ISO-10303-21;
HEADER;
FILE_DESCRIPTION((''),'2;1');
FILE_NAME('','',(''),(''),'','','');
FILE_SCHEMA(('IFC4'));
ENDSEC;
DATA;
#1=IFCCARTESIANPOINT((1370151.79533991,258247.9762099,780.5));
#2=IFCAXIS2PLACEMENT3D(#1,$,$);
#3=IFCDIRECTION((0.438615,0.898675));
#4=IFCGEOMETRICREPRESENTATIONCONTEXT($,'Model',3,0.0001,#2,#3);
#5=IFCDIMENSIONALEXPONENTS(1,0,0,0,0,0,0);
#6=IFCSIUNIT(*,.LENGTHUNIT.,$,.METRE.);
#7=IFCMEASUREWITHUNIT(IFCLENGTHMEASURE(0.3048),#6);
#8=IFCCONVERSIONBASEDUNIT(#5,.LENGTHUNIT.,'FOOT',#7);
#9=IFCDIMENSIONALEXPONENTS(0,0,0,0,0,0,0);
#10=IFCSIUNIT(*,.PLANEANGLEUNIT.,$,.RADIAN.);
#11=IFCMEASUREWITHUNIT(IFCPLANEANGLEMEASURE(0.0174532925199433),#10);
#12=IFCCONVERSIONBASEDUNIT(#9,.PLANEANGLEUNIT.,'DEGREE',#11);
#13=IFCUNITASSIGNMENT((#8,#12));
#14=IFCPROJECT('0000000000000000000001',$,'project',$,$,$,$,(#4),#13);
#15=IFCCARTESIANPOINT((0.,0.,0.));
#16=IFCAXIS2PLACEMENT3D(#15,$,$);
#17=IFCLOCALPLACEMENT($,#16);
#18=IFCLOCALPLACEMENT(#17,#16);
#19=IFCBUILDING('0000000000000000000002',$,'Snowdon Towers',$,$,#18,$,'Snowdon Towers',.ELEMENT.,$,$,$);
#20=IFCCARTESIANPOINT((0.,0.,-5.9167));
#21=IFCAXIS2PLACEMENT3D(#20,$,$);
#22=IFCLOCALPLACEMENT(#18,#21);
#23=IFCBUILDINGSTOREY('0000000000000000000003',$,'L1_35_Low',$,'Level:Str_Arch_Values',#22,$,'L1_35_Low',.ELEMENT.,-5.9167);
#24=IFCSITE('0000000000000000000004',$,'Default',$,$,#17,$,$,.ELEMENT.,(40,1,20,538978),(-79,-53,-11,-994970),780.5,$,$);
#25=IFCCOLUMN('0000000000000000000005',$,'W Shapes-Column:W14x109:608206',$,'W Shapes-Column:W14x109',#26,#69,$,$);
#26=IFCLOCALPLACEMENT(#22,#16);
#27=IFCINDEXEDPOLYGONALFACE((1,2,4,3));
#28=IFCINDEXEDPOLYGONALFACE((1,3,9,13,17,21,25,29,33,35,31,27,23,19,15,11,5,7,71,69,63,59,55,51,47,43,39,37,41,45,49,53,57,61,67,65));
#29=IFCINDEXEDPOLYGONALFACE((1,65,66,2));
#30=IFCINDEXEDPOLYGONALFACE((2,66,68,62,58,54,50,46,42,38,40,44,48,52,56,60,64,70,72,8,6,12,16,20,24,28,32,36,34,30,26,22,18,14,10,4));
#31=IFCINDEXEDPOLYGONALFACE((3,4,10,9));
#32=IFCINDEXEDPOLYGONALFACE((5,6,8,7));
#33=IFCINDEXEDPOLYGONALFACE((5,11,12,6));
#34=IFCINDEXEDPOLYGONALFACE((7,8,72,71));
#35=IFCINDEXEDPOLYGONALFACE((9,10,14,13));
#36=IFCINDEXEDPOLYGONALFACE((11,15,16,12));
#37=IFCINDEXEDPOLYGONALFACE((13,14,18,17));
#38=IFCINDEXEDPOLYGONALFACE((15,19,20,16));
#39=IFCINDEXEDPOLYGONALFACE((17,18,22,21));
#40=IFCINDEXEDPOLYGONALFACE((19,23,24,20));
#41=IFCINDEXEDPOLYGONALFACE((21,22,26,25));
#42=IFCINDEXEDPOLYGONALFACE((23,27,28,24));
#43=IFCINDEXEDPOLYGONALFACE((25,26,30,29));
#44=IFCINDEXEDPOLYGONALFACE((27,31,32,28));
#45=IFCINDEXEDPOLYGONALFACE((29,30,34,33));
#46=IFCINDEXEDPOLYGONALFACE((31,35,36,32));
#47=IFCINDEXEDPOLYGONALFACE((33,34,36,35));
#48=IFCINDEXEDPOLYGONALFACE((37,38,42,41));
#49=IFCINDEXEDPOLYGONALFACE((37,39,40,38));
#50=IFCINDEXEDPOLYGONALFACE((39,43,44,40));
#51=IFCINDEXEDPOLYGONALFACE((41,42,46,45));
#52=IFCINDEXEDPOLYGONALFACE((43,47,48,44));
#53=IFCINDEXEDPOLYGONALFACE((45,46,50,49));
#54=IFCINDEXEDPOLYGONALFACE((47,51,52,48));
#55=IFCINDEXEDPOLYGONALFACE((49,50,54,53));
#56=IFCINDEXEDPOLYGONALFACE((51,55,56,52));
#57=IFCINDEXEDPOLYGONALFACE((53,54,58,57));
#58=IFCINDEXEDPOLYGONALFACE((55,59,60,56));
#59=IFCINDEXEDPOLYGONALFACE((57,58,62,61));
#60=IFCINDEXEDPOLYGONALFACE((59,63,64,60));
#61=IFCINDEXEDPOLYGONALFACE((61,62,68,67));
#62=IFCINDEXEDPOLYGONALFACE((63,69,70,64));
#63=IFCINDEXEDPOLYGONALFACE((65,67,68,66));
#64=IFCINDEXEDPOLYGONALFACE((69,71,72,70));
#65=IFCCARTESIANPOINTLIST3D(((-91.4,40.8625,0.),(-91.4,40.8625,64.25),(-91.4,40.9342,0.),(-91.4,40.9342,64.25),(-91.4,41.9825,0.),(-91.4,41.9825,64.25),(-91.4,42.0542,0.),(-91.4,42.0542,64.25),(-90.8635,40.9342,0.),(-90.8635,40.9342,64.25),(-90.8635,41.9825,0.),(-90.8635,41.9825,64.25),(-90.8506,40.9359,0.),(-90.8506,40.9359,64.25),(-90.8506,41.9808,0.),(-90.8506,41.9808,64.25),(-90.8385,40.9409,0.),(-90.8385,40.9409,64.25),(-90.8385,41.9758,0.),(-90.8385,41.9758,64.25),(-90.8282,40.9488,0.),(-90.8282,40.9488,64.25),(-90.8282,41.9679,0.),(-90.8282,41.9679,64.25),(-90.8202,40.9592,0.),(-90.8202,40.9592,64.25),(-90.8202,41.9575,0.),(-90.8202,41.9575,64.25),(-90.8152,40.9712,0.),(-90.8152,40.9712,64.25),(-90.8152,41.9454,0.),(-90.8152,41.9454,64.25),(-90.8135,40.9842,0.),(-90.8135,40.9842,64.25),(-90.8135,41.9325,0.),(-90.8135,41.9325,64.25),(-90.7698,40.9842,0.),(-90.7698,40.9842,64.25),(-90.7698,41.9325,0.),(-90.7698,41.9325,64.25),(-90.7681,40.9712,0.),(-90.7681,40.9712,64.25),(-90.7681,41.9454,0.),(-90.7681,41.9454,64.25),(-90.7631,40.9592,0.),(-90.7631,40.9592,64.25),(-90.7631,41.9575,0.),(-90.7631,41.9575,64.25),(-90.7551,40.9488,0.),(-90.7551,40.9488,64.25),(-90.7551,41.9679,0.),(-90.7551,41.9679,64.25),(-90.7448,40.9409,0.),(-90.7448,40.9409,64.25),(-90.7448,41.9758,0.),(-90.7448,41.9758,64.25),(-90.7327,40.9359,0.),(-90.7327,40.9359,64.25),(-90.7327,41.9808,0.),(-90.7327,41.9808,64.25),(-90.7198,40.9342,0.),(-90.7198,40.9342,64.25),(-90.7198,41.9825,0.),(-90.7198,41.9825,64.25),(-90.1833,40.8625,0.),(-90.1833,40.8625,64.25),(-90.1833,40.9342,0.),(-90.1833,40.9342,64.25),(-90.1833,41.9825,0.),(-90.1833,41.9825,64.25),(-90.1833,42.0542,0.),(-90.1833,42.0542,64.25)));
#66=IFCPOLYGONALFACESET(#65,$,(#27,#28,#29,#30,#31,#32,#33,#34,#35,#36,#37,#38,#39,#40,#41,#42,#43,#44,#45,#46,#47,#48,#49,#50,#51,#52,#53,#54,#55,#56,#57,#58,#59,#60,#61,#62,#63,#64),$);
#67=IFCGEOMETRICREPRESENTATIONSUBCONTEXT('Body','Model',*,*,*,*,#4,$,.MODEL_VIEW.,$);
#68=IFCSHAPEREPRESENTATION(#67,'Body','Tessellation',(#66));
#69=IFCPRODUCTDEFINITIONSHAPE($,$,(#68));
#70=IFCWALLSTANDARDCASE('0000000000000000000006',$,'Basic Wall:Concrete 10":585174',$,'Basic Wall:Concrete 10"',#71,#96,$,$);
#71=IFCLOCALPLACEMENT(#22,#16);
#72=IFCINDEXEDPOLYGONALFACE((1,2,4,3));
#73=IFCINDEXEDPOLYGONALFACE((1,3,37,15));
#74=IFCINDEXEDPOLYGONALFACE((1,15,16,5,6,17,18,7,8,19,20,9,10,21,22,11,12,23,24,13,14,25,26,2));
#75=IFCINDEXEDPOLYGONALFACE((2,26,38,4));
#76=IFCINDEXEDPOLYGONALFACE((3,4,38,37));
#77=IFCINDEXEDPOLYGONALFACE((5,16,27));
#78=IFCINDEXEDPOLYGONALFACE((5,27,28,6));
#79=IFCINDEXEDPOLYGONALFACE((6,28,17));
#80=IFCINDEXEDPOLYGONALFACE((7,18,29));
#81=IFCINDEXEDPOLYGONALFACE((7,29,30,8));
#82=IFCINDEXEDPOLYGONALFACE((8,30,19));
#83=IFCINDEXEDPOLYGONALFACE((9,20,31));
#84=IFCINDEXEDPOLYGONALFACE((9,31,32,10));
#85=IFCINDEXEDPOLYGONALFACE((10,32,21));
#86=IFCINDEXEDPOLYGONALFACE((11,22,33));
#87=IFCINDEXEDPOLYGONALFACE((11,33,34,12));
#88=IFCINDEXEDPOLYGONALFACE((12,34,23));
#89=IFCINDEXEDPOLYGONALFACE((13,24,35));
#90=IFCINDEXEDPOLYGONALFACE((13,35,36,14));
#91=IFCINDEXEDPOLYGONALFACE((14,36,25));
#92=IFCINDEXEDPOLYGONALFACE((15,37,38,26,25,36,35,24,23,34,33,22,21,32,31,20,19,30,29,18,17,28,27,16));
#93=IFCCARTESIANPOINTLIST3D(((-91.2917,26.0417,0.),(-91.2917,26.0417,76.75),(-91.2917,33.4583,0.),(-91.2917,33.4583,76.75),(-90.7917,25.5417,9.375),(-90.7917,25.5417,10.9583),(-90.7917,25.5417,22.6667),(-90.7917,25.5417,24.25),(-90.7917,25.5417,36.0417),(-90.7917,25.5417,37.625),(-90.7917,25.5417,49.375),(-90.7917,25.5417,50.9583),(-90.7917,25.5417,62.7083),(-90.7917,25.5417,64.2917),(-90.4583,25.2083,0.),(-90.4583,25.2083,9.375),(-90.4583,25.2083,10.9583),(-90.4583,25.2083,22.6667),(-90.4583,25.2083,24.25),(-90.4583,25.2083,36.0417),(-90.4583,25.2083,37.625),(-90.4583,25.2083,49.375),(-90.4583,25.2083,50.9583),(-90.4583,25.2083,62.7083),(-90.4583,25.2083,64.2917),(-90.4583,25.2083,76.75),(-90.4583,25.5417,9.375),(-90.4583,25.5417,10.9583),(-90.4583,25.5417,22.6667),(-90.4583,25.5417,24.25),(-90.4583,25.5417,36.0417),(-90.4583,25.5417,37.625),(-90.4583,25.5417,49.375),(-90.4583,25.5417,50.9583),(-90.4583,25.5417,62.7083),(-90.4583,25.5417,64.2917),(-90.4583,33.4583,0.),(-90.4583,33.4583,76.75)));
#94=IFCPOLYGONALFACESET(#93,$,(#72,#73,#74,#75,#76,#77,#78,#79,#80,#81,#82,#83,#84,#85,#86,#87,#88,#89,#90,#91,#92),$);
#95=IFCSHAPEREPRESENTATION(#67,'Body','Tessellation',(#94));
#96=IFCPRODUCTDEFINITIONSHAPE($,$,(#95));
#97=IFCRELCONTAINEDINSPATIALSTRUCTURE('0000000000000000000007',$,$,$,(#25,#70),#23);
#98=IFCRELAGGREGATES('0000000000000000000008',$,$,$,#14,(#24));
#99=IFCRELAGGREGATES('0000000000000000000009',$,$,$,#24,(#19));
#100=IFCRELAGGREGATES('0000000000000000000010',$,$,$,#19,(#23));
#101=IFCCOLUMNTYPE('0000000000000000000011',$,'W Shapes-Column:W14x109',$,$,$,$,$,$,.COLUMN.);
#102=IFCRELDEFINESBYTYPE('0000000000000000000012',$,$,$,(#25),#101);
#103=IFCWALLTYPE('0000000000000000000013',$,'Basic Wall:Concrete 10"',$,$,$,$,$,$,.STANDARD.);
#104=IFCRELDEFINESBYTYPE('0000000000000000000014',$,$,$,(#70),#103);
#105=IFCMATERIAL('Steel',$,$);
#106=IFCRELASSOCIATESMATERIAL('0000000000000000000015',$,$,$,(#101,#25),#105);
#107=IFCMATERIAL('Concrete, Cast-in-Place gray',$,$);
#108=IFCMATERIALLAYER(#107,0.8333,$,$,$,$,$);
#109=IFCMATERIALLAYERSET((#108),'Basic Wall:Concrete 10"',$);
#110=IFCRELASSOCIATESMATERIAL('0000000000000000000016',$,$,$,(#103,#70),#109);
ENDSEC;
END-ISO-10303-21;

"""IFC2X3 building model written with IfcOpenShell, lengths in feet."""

from ifc_helpers import new_model, entity, si_unit, converted_unit, direction, frame, frame_2d, origin, place, context, subcontext, project, spatial, polyline, rectangle, i_section, outline, extrude, source, transform, mapped, material, layer, layer_set, layer_usage, type_object, type_shapes, element, save


model = new_model("IFC2X3")

# Units and contexts
model_context = context("Model", 3, precision=0.0001, world=frame((1370151.79533991, 258247.9762099, 780.5)), true_north=direction((0.438615, 0.898675)))
body_context = subcontext(model_context, "Body", "Model", "MODEL_VIEW")
ifc_project = project(units=[converted_unit("LENGTHUNIT", "FOOT", entity("IfcLengthMeasure", 0.3048), si_unit("LENGTHUNIT", "METRE"), dimensions=[1, 0, 0, 0, 0, 0, 0]), converted_unit("PLANEANGLEUNIT", "DEGREE", entity("IfcPlaneAngleMeasure", 0.0174532925199433), si_unit("PLANEANGLEUNIT", "RADIAN"), dimensions=[0, 0, 0, 0, 0, 0, 0])], contexts=[model_context])

# Site, building, storey
site_placement = place(None, origin())
site = spatial("IfcSite", under=ifc_project, at=site_placement, Name="Default", CompositionType="ELEMENT", RefLatitude=(40, 1, 20, 538978), RefLongitude=(-79, -53, -11, -994970), RefElevation=780.5)
building_placement = place(site_placement, origin())
building = spatial("IfcBuilding", under=site, at=building_placement, Name="Snowdon Towers", LongName="Snowdon Towers", CompositionType="ELEMENT")
storey_placement = place(building_placement, frame((0.0, 0.0, -5.9167)))
storey = spatial("IfcBuildingStorey", under=building, at=storey_placement, Name="L1_35_Low", ObjectType="Level:Str_Arch_Values", LongName="L1_35_Low", CompositionType="ELEMENT", Elevation=-5.9167)

# Column
ifc_material_1 = material(Name="Steel")
column_type = type_object("IfcColumnType", Name="W Shapes-Column:W14x109", PredefinedType="COLUMN", material=ifc_material_1)
shared_shape = source(origin(), body_context, "Body", "SweptSolid", [
    extrude(i_section(OverallWidth=1.2167, OverallDepth=1.1917, WebThickness=0.0438, FlangeThickness=0.0717, FilletRadius=0.05, at=frame_2d((0.0, 0.0), x_axis=(1.0, 0.0))), frame((0.0, 0.0, -5.9167), z_axis=(0.0, 0.0, 1.0), x_axis=(-1.0, 0.0, 0.0)), (0.0, 0.0, 1.0), 64.25),
])
type_shapes(column_type, [shared_shape])
column_placement = place(storey_placement, frame((-90.7917, 41.4583, 5.9167), z_axis=(0.0, 0.0, 1.0), x_axis=(-1.0, 0.0, 0.0)))
element("IfcColumn", 1, at=column_placement, inside=storey, type_object=column_type, material=ifc_material_1, Name="W Shapes-Column:W14x109:608206", ObjectType="W Shapes-Column:W14x109", context=body_context, shape_type="MappedRepresentation", body=[
    mapped(shared_shape, transform((0.0, 0.0, 0.0), scale=1.0)),
])

# Wall, openings
ifc_material_2 = material(Name="Concrete, Cast-in-Place gray")
ifc_layer = layer(ifc_material_2, 0.8333)
ifc_layer_set = layer_set([ifc_layer], Name="Basic Wall:Concrete 10\"")
wall_type = type_object("IfcWallType", Name="Basic Wall:Concrete 10\"", PredefinedType="STANDARD", material=ifc_layer_set)
ifc_layer_usage_1 = layer_usage(ifc_layer_set, "AXIS2", "POSITIVE", -0.4167)
wall_1_placement = place(storey_placement, frame((-90.875, 33.4583, 0.0), z_axis=(0.0, 0.0, 1.0), x_axis=(0.0, -1.0, 0.0)))
wall_1 = element("IfcWallStandardCase", 2, at=wall_1_placement, inside=storey, type_object=wall_type, material=ifc_layer_usage_1, Name="Basic Wall:Concrete 10\":585174", ObjectType="Basic Wall:Concrete 10\"", context=body_context, shape_type="SweptSolid", body=[
    extrude(outline(polyline([(7.4167, -0.4167), (8.25, 0.4167), (0.0, 0.4167), (0.0, -0.4167), (7.4167, -0.4167)])), origin(), (0.0, 0.0, 1.0), 76.75),
])
opening_1_placement = place(wall_1_placement, origin())
element("IfcOpeningElement", 3, at=opening_1_placement, cuts=wall_1, ObjectType="Opening", context=body_context, shape_type="SweptSolid", body=[
    extrude(rectangle(XDim=1.5833, YDim=0.3333, at=frame_2d((0.0, 0.0), x_axis=(0.0, 1.0))), frame((8.0833, -0.5, 23.4583), z_axis=(0.0, 1.0, 0.0), x_axis=(1.0, 0.0, 0.0)), (0.0, 0.0, 1.0), 1.0),
])
opening_2_placement = place(wall_1_placement, origin())
element("IfcOpeningElement", 4, at=opening_2_placement, cuts=wall_1, ObjectType="Opening", context=body_context, shape_type="SweptSolid", body=[
    extrude(rectangle(XDim=1.5833, YDim=0.3333, at=frame_2d((0.0, 0.0), x_axis=(0.0, 1.0))), frame((8.0833, -0.5, 10.1667), z_axis=(0.0, 1.0, 0.0), x_axis=(1.0, 0.0, 0.0)), (0.0, 0.0, 1.0), 1.0),
])
opening_3_placement = place(wall_1_placement, origin())
element("IfcOpeningElement", 5, at=opening_3_placement, cuts=wall_1, ObjectType="Opening", context=body_context, shape_type="SweptSolid", body=[
    extrude(rectangle(XDim=1.5833, YDim=0.3333, at=frame_2d((0.0, 0.0), x_axis=(0.0, 1.0))), frame((8.0833, -0.5, 63.5), z_axis=(0.0, 1.0, 0.0), x_axis=(1.0, 0.0, 0.0)), (0.0, 0.0, 1.0), 1.0),
])
opening_4_placement = place(wall_1_placement, origin())
element("IfcOpeningElement", 6, at=opening_4_placement, cuts=wall_1, ObjectType="Opening", context=body_context, shape_type="SweptSolid", body=[
    extrude(rectangle(XDim=1.5833, YDim=0.3333, at=frame_2d((0.0, 0.0), x_axis=(0.0, 1.0))), frame((8.0833, -0.5, 36.8333), z_axis=(0.0, 1.0, 0.0), x_axis=(1.0, 0.0, 0.0)), (0.0, 0.0, 1.0), 1.0),
])
opening_5_placement = place(wall_1_placement, origin())
element("IfcOpeningElement", 7, at=opening_5_placement, cuts=wall_1, ObjectType="Opening", context=body_context, shape_type="SweptSolid", body=[
    extrude(rectangle(XDim=1.5833, YDim=0.3333, at=frame_2d((0.0, 0.0), x_axis=(0.0, 1.0))), frame((8.0833, -0.5, 50.1667), z_axis=(0.0, 1.0, 0.0), x_axis=(1.0, 0.0, 0.0)), (0.0, 0.0, 1.0), 1.0),
])
opening_6_placement = place(wall_1_placement, origin())
element("IfcOpeningElement", 8, at=opening_6_placement, cuts=wall_1, ObjectType="Opening", context=body_context, shape_type="SweptSolid", body=[
    extrude(rectangle(XDim=1.5833, YDim=0.3333, at=frame_2d((0.0, 0.0), x_axis=(0.0, 1.0))), frame((-0.6667, -0.5, 23.4583), z_axis=(0.0, 1.0, 0.0), x_axis=(-1.0, 0.0, 0.0)), (0.0, 0.0, 1.0), 1.0),
])
opening_7_placement = place(wall_1_placement, origin())
element("IfcOpeningElement", 9, at=opening_7_placement, cuts=wall_1, ObjectType="Opening", context=body_context, shape_type="SweptSolid", body=[
    extrude(rectangle(XDim=1.5833, YDim=0.3333, at=frame_2d((0.0, 0.0), x_axis=(0.0, 1.0))), frame((-0.6667, -0.5, 10.1667), z_axis=(0.0, 1.0, 0.0), x_axis=(-1.0, 0.0, 0.0)), (0.0, 0.0, 1.0), 1.0),
])
opening_8_placement = place(wall_1_placement, origin())
element("IfcOpeningElement", 10, at=opening_8_placement, cuts=wall_1, ObjectType="Opening", context=body_context, shape_type="SweptSolid", body=[
    extrude(rectangle(XDim=1.5833, YDim=0.3333, at=frame_2d((0.0, 0.0), x_axis=(0.0, 1.0))), frame((-0.6667, -0.5, 63.5), z_axis=(0.0, 1.0, 0.0), x_axis=(-1.0, 0.0, 0.0)), (0.0, 0.0, 1.0), 1.0),
])
opening_9_placement = place(wall_1_placement, origin())
element("IfcOpeningElement", 11, at=opening_9_placement, cuts=wall_1, ObjectType="Opening", context=body_context, shape_type="SweptSolid", body=[
    extrude(rectangle(XDim=1.5833, YDim=0.3333, at=frame_2d((0.0, 0.0), x_axis=(0.0, 1.0))), frame((-0.6667, -0.5, 36.8333), z_axis=(0.0, 1.0, 0.0), x_axis=(-1.0, 0.0, 0.0)), (0.0, 0.0, 1.0), 1.0),
])
opening_10_placement = place(wall_1_placement, origin())
element("IfcOpeningElement", 12, at=opening_10_placement, cuts=wall_1, ObjectType="Opening", context=body_context, shape_type="SweptSolid", body=[
    extrude(rectangle(XDim=1.5833, YDim=0.3333, at=frame_2d((0.0, 0.0), x_axis=(0.0, 1.0))), frame((-0.6667, -0.5, 50.1667), z_axis=(0.0, 1.0, 0.0), x_axis=(-1.0, 0.0, 0.0)), (0.0, 0.0, 1.0), 1.0),
])

save(model, "model.ifc")
